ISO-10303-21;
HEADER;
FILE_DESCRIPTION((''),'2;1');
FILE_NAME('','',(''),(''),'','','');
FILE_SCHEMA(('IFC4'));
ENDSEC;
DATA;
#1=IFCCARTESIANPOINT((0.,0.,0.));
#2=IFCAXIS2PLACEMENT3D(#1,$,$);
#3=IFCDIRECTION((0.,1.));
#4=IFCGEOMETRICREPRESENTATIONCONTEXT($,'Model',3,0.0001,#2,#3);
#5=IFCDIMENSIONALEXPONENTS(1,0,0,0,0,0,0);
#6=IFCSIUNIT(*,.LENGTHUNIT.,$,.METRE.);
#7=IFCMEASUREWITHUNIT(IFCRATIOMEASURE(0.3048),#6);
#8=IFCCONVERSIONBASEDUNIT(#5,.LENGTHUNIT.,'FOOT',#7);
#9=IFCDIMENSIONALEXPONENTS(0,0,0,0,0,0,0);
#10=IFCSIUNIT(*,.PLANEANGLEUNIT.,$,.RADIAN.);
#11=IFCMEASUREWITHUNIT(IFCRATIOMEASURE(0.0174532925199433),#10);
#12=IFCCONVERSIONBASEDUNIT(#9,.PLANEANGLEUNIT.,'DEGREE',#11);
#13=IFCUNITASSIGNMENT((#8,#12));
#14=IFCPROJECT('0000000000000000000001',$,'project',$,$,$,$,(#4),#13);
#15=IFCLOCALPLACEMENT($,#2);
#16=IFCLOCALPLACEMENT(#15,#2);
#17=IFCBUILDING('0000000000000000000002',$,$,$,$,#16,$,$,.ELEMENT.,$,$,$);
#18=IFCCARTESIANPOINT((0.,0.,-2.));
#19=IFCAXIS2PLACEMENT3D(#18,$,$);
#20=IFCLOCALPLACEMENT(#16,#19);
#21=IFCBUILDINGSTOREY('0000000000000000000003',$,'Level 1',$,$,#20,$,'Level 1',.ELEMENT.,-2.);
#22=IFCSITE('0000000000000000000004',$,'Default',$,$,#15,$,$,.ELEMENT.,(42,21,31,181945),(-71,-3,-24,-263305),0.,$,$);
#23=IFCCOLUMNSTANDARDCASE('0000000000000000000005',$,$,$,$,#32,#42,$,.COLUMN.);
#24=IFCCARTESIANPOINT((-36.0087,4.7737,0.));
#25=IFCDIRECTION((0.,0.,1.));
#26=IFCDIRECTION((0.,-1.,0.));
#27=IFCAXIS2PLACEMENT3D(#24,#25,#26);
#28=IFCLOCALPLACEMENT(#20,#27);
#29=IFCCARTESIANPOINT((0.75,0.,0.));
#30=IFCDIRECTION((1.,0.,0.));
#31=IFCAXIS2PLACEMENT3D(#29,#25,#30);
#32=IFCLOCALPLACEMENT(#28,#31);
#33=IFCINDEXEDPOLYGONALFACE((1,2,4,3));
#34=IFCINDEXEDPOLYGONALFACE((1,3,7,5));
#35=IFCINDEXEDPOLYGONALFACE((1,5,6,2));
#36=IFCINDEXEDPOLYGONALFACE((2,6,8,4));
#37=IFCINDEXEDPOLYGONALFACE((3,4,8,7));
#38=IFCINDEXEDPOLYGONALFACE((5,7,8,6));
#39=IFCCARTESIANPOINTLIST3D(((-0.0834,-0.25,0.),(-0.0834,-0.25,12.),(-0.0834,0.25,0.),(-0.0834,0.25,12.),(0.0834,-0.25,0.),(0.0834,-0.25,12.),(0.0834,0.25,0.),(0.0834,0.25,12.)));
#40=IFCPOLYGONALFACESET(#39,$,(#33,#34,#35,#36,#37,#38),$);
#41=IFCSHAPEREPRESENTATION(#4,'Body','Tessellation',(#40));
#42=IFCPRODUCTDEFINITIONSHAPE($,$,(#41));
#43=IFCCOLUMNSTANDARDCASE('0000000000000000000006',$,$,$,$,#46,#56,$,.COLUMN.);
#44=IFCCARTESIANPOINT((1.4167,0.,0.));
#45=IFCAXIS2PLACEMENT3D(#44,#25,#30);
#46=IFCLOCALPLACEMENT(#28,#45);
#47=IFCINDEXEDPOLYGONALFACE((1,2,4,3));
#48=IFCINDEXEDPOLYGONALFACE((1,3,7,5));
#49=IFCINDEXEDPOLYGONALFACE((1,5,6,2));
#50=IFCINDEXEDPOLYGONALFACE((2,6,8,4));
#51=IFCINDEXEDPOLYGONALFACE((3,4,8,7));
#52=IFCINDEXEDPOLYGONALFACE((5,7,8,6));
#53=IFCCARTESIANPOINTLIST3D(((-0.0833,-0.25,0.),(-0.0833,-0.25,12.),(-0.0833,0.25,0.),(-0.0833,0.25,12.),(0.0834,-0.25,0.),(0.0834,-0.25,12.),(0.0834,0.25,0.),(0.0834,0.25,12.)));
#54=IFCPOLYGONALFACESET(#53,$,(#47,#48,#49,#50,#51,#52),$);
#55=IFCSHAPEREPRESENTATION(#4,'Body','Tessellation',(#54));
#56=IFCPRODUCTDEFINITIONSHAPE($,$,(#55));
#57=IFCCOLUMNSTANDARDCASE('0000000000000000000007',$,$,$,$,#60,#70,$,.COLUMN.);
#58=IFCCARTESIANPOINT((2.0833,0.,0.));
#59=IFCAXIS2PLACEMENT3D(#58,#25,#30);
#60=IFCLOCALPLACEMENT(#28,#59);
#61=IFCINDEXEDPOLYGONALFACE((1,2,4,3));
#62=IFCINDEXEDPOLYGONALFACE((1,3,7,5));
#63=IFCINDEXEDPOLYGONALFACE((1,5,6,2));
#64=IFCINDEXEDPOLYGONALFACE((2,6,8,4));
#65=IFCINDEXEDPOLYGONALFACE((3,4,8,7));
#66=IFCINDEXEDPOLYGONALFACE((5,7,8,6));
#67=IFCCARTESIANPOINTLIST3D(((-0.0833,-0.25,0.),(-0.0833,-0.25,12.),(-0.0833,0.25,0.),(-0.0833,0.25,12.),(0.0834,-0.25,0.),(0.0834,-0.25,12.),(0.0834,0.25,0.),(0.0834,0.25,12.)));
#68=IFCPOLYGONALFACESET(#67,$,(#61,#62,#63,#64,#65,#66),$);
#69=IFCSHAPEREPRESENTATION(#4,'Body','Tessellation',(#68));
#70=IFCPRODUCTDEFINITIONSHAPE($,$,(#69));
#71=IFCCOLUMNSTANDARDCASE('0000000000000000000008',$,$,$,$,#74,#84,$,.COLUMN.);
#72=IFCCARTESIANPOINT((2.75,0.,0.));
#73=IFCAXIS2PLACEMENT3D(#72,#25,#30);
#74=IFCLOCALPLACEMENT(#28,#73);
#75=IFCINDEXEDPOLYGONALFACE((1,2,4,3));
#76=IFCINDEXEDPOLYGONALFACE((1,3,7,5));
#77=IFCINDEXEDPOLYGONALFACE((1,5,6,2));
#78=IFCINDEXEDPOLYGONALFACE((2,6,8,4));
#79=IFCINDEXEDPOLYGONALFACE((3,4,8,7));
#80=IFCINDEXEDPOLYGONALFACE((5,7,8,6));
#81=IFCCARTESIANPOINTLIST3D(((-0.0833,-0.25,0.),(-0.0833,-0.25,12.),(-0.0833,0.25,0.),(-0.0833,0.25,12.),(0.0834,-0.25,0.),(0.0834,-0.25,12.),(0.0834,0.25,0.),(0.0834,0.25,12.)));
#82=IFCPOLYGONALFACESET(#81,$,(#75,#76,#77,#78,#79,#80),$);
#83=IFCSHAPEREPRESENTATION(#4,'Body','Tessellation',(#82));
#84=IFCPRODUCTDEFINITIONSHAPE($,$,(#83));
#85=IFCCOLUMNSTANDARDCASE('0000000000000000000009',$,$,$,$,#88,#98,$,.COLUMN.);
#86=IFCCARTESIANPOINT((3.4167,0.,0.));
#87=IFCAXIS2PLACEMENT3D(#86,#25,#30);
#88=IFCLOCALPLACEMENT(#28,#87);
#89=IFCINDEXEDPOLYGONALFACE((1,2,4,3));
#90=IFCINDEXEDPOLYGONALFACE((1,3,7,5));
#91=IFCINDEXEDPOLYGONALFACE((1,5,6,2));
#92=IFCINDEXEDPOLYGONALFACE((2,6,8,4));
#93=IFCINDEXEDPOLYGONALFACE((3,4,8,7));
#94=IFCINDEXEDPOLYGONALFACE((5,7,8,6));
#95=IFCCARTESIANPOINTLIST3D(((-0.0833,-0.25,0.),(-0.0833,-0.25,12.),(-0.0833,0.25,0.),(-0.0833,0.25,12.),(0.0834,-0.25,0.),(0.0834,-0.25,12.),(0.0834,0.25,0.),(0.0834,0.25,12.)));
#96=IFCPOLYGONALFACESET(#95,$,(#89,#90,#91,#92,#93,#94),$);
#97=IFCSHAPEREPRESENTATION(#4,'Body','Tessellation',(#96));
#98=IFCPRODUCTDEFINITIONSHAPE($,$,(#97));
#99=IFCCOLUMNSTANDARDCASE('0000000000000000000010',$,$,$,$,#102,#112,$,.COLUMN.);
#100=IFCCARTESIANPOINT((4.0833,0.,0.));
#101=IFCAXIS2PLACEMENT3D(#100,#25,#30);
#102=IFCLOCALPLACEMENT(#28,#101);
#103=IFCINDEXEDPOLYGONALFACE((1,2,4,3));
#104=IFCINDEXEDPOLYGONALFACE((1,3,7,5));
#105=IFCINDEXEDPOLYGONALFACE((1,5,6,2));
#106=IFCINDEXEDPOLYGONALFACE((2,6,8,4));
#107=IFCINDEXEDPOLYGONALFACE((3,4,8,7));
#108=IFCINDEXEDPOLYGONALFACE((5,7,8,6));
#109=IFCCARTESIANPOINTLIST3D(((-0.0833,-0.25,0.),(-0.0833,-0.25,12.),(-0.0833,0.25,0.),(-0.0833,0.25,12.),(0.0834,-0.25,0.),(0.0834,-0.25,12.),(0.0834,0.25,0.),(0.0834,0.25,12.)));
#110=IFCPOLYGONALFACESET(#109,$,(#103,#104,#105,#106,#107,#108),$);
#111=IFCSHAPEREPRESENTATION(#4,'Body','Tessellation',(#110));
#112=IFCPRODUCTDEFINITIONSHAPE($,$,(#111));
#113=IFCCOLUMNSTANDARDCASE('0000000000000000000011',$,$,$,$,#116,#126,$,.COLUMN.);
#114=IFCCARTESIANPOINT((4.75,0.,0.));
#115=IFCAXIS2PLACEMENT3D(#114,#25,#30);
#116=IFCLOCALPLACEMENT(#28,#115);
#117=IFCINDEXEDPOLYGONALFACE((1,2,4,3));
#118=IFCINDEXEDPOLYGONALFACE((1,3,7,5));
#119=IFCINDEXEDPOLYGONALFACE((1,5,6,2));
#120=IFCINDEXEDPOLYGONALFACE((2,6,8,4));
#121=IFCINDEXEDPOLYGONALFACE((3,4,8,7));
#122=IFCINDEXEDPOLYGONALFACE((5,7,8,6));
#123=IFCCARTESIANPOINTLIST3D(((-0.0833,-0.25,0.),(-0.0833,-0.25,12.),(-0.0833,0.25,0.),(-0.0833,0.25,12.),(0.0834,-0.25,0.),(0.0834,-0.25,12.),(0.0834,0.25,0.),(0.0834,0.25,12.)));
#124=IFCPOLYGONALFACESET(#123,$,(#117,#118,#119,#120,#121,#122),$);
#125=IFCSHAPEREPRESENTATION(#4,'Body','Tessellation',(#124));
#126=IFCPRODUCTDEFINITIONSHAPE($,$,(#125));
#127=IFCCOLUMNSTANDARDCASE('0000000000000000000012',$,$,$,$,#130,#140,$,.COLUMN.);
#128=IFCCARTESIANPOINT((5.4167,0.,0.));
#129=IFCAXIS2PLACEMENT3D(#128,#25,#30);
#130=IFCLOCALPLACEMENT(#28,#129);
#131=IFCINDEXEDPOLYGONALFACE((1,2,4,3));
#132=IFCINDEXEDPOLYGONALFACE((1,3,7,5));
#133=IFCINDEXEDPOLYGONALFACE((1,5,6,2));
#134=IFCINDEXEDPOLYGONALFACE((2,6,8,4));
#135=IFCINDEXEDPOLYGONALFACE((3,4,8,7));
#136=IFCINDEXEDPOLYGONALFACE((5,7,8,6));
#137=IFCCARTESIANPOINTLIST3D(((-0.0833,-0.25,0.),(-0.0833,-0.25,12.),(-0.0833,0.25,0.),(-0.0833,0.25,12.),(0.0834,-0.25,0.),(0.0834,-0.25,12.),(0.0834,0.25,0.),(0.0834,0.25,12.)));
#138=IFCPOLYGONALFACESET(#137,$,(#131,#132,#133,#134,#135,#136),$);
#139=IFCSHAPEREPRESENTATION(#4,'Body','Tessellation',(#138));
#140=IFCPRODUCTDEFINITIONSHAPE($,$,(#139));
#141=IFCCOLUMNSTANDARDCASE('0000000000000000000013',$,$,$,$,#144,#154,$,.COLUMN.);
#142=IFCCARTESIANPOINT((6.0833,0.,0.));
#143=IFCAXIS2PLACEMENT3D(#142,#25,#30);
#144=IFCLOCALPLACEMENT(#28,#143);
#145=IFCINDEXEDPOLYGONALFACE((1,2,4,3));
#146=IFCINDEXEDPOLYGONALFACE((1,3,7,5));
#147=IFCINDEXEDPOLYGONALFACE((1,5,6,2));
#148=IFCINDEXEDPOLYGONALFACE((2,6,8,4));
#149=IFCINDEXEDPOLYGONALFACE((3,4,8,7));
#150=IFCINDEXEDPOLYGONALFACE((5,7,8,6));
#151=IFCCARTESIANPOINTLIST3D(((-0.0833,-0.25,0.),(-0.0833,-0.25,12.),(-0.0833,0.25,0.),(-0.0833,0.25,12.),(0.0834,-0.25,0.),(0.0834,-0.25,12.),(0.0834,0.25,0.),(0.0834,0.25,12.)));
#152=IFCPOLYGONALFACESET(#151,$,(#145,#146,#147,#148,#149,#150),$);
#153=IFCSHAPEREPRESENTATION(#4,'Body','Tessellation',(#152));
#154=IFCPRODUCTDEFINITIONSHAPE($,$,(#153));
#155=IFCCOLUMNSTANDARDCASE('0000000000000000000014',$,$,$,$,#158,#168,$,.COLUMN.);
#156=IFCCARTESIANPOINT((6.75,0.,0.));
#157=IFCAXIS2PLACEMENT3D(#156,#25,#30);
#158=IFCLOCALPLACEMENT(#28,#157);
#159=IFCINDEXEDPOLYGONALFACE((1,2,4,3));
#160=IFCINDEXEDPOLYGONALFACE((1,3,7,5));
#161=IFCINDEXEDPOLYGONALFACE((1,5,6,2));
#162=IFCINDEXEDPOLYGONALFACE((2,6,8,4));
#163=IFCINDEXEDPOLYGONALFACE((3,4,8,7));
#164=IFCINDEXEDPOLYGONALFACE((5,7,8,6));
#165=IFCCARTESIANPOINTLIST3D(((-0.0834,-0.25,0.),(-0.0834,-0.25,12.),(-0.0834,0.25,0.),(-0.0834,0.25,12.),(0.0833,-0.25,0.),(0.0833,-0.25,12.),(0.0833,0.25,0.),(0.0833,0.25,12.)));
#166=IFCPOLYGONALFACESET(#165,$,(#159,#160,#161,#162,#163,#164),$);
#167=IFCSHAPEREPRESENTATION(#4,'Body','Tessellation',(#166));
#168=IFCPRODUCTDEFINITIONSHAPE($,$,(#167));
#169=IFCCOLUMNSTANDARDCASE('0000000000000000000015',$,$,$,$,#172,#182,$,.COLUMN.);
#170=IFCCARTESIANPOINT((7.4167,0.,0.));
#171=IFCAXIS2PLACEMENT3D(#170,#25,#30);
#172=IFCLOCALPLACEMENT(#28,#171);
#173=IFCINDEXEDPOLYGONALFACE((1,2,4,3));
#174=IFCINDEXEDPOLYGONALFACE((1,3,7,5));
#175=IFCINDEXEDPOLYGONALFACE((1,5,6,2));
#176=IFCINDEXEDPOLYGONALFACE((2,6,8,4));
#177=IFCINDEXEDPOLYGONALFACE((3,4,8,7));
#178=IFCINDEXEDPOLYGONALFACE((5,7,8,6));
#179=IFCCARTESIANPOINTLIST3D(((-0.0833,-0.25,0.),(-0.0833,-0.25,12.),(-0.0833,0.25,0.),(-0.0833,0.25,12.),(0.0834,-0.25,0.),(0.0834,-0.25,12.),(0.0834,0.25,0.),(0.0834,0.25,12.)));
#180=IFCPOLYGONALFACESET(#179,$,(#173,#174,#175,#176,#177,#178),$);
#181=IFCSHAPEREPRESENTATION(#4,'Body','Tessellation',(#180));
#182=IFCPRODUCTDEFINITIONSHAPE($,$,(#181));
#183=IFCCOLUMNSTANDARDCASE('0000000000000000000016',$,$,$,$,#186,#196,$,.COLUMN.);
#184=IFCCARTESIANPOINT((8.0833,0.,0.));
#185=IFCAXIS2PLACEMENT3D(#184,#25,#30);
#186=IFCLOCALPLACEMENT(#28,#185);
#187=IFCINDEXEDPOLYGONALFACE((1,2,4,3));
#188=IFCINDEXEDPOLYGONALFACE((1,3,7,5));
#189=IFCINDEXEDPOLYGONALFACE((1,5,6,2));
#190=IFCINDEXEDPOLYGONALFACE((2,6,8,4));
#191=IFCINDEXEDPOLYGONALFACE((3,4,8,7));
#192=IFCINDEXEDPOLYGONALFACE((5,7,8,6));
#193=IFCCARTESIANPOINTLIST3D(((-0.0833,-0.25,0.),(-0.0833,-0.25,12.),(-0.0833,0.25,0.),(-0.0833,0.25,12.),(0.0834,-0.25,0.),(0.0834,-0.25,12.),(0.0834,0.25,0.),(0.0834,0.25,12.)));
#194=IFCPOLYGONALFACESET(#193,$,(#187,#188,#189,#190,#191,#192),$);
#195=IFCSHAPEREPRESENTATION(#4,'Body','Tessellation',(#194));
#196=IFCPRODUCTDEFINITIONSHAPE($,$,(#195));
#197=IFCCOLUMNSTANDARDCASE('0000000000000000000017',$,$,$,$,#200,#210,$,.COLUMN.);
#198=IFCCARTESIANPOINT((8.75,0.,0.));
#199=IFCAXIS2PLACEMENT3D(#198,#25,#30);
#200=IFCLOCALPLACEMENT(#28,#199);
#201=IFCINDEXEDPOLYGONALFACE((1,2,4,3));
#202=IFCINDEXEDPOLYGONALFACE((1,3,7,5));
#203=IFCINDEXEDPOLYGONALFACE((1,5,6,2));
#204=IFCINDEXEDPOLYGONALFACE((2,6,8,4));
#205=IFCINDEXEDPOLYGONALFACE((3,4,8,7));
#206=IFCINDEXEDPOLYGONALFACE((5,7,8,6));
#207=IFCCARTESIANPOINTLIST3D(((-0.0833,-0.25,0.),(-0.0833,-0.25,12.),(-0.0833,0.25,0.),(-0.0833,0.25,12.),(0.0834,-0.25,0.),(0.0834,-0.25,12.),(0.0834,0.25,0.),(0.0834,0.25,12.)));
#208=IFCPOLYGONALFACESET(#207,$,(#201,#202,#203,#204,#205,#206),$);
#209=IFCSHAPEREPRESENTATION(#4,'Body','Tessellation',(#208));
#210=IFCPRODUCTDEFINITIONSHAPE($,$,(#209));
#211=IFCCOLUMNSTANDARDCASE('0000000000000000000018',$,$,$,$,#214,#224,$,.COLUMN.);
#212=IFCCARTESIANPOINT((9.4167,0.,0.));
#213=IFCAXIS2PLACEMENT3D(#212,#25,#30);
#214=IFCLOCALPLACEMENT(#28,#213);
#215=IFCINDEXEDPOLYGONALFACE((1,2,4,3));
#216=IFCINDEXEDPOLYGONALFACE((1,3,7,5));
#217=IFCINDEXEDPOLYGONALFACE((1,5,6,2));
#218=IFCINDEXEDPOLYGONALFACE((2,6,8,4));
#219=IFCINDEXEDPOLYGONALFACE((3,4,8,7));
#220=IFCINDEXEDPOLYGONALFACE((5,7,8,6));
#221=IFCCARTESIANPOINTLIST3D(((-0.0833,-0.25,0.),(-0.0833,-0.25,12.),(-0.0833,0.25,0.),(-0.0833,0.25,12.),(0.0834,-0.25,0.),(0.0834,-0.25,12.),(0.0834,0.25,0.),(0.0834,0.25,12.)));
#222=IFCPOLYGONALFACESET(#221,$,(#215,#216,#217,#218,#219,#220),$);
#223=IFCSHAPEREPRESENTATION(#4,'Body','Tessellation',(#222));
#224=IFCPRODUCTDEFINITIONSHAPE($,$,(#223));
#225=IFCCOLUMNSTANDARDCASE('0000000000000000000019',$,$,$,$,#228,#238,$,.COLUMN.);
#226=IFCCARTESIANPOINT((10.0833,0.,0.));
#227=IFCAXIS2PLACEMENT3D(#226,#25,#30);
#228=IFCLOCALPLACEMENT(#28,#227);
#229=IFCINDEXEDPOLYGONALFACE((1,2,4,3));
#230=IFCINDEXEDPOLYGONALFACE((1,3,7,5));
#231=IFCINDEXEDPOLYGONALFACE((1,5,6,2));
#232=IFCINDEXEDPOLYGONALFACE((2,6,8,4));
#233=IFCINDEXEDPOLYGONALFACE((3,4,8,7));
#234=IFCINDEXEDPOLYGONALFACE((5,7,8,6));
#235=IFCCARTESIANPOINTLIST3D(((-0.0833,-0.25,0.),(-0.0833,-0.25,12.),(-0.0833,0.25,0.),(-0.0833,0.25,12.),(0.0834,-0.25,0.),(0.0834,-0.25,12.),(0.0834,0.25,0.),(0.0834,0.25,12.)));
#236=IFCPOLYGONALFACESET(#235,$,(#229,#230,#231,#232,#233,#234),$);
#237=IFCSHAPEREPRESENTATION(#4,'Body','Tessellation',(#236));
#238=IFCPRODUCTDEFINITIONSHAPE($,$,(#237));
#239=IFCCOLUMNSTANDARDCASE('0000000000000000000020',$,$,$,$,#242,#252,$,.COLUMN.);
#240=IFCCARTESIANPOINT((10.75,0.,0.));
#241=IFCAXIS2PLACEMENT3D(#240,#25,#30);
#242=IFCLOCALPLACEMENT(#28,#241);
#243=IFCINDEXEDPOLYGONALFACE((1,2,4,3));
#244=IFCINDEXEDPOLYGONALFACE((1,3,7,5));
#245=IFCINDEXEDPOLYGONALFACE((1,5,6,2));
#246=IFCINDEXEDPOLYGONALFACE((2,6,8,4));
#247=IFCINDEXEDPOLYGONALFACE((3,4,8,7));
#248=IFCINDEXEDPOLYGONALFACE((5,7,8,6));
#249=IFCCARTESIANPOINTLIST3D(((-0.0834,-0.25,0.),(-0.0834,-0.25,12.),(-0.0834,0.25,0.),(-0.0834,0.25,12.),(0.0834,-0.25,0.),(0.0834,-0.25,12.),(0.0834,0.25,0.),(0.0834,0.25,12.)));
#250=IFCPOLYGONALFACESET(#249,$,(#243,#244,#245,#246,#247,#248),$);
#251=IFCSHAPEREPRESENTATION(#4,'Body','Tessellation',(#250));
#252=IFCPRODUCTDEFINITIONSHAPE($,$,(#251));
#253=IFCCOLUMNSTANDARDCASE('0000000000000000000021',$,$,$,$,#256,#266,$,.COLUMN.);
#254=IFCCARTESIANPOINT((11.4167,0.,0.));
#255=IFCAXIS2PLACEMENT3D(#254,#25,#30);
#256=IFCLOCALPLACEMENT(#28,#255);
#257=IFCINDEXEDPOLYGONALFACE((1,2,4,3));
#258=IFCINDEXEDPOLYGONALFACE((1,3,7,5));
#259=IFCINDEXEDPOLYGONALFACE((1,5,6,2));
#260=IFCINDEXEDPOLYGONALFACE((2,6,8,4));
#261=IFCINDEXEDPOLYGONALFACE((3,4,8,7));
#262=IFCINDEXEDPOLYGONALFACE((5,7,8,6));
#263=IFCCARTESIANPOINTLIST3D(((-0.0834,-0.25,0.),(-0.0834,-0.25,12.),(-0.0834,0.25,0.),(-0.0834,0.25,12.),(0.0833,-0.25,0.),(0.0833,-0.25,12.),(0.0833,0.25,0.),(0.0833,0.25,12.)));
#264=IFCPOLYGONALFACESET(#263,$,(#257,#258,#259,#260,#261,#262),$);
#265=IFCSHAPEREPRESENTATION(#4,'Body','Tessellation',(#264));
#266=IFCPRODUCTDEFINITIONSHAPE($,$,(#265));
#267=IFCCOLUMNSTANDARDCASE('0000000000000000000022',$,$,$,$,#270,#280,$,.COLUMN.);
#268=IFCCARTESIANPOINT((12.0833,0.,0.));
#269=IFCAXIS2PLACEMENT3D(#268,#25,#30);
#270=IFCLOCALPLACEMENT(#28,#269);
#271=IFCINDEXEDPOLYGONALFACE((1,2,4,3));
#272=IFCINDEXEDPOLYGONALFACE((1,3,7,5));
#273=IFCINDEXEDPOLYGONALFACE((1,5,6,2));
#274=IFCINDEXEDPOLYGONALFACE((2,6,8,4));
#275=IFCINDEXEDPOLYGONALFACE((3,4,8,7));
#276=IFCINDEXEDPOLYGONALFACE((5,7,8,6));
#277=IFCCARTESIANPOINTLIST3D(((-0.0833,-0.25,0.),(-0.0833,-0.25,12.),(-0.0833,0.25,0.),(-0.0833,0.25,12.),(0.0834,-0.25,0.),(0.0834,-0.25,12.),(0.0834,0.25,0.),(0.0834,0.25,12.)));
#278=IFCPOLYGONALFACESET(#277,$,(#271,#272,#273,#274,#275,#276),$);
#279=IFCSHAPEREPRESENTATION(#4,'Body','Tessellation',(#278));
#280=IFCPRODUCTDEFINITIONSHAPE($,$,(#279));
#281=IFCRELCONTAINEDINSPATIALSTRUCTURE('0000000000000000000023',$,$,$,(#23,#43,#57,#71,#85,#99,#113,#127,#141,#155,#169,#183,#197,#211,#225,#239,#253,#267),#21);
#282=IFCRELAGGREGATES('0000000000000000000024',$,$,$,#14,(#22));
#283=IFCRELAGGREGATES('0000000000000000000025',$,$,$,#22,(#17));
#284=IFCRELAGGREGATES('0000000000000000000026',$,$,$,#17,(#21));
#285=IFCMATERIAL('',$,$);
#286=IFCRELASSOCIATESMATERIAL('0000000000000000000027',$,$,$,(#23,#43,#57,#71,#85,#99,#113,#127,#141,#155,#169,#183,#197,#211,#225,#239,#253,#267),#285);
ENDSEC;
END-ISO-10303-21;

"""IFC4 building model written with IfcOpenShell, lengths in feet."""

from ifc_helpers import new_model, entity, si_unit, converted_unit, direction, frame, origin, place, context, project, spatial, rectangle, extrude, material, element, save


model = new_model("IFC4")

# Units and contexts
model_context = context("Model", 3, precision=0.0001, world=origin(), true_north=direction((0.0, 1.0)))
ifc_project = project(units=[converted_unit("LENGTHUNIT", "FOOT", entity("IfcRatioMeasure", 0.3048), si_unit("LENGTHUNIT", "METRE"), dimensions=[1, 0, 0, 0, 0, 0, 0]), converted_unit("PLANEANGLEUNIT", "DEGREE", entity("IfcRatioMeasure", 0.0174532925199433), si_unit("PLANEANGLEUNIT", "RADIAN"), dimensions=[0, 0, 0, 0, 0, 0, 0])], contexts=[model_context])

# Site, building, storey
site_placement = place(None, origin())
site = spatial("IfcSite", under=ifc_project, at=site_placement, Name="Default", CompositionType="ELEMENT", RefLatitude=(42, 21, 31, 181945), RefLongitude=(-71, -3, -24, -263305), RefElevation=0.0)
building_placement = place(site_placement, origin())
building = spatial("IfcBuilding", under=site, at=building_placement, CompositionType="ELEMENT")
storey_placement = place(building_placement, frame((0.0, 0.0, -2.0)))
storey = spatial("IfcBuildingStorey", under=building, at=storey_placement, Name="Level 1", LongName="Level 1", CompositionType="ELEMENT", Elevation=-2.0)

# Columns
ifc_material_1 = material(Name="")
placement = place(storey_placement, frame((-36.0087, 4.7737, 0.0), z_axis=(0.0, 0.0, 1.0), x_axis=(0.0, -1.0, 0.0)))
for number, where, z_axis, x_axis in (
    (1, (0.75, 0.0, 0.0), (0.0, 0.0, 1.0), (1.0, 0.0, 0.0)),
    (2, (1.4167, 0.0, 0.0), (0.0, 0.0, 1.0), (1.0, 0.0, 0.0)),
    (3, (2.0833, 0.0, 0.0), (0.0, 0.0, 1.0), (1.0, 0.0, 0.0)),
    (4, (2.75, 0.0, 0.0), (0.0, 0.0, 1.0), (1.0, 0.0, 0.0)),
    (5, (3.4167, 0.0, 0.0), (0.0, 0.0, 1.0), (1.0, 0.0, 0.0)),
    (6, (4.0833, 0.0, 0.0), (0.0, 0.0, 1.0), (1.0, 0.0, 0.0)),
    (7, (4.75, 0.0, 0.0), (0.0, 0.0, 1.0), (1.0, 0.0, 0.0)),
    (8, (5.4167, 0.0, 0.0), (0.0, 0.0, 1.0), (1.0, 0.0, 0.0)),
    (9, (6.0833, 0.0, 0.0), (0.0, 0.0, 1.0), (1.0, 0.0, 0.0)),
    (10, (6.75, 0.0, 0.0), (0.0, 0.0, 1.0), (1.0, 0.0, 0.0)),
    (11, (7.4167, 0.0, 0.0), (0.0, 0.0, 1.0), (1.0, 0.0, 0.0)),
    (12, (8.0833, 0.0, 0.0), (0.0, 0.0, 1.0), (1.0, 0.0, 0.0)),
    (13, (8.75, 0.0, 0.0), (0.0, 0.0, 1.0), (1.0, 0.0, 0.0)),
    (14, (9.4167, 0.0, 0.0), (0.0, 0.0, 1.0), (1.0, 0.0, 0.0)),
    (15, (10.0833, 0.0, 0.0), (0.0, 0.0, 1.0), (1.0, 0.0, 0.0)),
    (16, (10.75, 0.0, 0.0), (0.0, 0.0, 1.0), (1.0, 0.0, 0.0)),
    (17, (11.4167, 0.0, 0.0), (0.0, 0.0, 1.0), (1.0, 0.0, 0.0)),
    (18, (12.0833, 0.0, 0.0), (0.0, 0.0, 1.0), (1.0, 0.0, 0.0)),
):
    element("IfcColumnStandardCase", number, at=place(placement, frame(where, z_axis=z_axis, x_axis=x_axis)), inside=storey, material=ifc_material_1, PredefinedType="COLUMN", context=model_context, shape_type="SweptSolid", body=[
        extrude(rectangle(XDim=0.1667, YDim=0.5), origin(), (0.0, 0.0, 1.0), 12.0),
    ])

save(model, "model.ifc")
